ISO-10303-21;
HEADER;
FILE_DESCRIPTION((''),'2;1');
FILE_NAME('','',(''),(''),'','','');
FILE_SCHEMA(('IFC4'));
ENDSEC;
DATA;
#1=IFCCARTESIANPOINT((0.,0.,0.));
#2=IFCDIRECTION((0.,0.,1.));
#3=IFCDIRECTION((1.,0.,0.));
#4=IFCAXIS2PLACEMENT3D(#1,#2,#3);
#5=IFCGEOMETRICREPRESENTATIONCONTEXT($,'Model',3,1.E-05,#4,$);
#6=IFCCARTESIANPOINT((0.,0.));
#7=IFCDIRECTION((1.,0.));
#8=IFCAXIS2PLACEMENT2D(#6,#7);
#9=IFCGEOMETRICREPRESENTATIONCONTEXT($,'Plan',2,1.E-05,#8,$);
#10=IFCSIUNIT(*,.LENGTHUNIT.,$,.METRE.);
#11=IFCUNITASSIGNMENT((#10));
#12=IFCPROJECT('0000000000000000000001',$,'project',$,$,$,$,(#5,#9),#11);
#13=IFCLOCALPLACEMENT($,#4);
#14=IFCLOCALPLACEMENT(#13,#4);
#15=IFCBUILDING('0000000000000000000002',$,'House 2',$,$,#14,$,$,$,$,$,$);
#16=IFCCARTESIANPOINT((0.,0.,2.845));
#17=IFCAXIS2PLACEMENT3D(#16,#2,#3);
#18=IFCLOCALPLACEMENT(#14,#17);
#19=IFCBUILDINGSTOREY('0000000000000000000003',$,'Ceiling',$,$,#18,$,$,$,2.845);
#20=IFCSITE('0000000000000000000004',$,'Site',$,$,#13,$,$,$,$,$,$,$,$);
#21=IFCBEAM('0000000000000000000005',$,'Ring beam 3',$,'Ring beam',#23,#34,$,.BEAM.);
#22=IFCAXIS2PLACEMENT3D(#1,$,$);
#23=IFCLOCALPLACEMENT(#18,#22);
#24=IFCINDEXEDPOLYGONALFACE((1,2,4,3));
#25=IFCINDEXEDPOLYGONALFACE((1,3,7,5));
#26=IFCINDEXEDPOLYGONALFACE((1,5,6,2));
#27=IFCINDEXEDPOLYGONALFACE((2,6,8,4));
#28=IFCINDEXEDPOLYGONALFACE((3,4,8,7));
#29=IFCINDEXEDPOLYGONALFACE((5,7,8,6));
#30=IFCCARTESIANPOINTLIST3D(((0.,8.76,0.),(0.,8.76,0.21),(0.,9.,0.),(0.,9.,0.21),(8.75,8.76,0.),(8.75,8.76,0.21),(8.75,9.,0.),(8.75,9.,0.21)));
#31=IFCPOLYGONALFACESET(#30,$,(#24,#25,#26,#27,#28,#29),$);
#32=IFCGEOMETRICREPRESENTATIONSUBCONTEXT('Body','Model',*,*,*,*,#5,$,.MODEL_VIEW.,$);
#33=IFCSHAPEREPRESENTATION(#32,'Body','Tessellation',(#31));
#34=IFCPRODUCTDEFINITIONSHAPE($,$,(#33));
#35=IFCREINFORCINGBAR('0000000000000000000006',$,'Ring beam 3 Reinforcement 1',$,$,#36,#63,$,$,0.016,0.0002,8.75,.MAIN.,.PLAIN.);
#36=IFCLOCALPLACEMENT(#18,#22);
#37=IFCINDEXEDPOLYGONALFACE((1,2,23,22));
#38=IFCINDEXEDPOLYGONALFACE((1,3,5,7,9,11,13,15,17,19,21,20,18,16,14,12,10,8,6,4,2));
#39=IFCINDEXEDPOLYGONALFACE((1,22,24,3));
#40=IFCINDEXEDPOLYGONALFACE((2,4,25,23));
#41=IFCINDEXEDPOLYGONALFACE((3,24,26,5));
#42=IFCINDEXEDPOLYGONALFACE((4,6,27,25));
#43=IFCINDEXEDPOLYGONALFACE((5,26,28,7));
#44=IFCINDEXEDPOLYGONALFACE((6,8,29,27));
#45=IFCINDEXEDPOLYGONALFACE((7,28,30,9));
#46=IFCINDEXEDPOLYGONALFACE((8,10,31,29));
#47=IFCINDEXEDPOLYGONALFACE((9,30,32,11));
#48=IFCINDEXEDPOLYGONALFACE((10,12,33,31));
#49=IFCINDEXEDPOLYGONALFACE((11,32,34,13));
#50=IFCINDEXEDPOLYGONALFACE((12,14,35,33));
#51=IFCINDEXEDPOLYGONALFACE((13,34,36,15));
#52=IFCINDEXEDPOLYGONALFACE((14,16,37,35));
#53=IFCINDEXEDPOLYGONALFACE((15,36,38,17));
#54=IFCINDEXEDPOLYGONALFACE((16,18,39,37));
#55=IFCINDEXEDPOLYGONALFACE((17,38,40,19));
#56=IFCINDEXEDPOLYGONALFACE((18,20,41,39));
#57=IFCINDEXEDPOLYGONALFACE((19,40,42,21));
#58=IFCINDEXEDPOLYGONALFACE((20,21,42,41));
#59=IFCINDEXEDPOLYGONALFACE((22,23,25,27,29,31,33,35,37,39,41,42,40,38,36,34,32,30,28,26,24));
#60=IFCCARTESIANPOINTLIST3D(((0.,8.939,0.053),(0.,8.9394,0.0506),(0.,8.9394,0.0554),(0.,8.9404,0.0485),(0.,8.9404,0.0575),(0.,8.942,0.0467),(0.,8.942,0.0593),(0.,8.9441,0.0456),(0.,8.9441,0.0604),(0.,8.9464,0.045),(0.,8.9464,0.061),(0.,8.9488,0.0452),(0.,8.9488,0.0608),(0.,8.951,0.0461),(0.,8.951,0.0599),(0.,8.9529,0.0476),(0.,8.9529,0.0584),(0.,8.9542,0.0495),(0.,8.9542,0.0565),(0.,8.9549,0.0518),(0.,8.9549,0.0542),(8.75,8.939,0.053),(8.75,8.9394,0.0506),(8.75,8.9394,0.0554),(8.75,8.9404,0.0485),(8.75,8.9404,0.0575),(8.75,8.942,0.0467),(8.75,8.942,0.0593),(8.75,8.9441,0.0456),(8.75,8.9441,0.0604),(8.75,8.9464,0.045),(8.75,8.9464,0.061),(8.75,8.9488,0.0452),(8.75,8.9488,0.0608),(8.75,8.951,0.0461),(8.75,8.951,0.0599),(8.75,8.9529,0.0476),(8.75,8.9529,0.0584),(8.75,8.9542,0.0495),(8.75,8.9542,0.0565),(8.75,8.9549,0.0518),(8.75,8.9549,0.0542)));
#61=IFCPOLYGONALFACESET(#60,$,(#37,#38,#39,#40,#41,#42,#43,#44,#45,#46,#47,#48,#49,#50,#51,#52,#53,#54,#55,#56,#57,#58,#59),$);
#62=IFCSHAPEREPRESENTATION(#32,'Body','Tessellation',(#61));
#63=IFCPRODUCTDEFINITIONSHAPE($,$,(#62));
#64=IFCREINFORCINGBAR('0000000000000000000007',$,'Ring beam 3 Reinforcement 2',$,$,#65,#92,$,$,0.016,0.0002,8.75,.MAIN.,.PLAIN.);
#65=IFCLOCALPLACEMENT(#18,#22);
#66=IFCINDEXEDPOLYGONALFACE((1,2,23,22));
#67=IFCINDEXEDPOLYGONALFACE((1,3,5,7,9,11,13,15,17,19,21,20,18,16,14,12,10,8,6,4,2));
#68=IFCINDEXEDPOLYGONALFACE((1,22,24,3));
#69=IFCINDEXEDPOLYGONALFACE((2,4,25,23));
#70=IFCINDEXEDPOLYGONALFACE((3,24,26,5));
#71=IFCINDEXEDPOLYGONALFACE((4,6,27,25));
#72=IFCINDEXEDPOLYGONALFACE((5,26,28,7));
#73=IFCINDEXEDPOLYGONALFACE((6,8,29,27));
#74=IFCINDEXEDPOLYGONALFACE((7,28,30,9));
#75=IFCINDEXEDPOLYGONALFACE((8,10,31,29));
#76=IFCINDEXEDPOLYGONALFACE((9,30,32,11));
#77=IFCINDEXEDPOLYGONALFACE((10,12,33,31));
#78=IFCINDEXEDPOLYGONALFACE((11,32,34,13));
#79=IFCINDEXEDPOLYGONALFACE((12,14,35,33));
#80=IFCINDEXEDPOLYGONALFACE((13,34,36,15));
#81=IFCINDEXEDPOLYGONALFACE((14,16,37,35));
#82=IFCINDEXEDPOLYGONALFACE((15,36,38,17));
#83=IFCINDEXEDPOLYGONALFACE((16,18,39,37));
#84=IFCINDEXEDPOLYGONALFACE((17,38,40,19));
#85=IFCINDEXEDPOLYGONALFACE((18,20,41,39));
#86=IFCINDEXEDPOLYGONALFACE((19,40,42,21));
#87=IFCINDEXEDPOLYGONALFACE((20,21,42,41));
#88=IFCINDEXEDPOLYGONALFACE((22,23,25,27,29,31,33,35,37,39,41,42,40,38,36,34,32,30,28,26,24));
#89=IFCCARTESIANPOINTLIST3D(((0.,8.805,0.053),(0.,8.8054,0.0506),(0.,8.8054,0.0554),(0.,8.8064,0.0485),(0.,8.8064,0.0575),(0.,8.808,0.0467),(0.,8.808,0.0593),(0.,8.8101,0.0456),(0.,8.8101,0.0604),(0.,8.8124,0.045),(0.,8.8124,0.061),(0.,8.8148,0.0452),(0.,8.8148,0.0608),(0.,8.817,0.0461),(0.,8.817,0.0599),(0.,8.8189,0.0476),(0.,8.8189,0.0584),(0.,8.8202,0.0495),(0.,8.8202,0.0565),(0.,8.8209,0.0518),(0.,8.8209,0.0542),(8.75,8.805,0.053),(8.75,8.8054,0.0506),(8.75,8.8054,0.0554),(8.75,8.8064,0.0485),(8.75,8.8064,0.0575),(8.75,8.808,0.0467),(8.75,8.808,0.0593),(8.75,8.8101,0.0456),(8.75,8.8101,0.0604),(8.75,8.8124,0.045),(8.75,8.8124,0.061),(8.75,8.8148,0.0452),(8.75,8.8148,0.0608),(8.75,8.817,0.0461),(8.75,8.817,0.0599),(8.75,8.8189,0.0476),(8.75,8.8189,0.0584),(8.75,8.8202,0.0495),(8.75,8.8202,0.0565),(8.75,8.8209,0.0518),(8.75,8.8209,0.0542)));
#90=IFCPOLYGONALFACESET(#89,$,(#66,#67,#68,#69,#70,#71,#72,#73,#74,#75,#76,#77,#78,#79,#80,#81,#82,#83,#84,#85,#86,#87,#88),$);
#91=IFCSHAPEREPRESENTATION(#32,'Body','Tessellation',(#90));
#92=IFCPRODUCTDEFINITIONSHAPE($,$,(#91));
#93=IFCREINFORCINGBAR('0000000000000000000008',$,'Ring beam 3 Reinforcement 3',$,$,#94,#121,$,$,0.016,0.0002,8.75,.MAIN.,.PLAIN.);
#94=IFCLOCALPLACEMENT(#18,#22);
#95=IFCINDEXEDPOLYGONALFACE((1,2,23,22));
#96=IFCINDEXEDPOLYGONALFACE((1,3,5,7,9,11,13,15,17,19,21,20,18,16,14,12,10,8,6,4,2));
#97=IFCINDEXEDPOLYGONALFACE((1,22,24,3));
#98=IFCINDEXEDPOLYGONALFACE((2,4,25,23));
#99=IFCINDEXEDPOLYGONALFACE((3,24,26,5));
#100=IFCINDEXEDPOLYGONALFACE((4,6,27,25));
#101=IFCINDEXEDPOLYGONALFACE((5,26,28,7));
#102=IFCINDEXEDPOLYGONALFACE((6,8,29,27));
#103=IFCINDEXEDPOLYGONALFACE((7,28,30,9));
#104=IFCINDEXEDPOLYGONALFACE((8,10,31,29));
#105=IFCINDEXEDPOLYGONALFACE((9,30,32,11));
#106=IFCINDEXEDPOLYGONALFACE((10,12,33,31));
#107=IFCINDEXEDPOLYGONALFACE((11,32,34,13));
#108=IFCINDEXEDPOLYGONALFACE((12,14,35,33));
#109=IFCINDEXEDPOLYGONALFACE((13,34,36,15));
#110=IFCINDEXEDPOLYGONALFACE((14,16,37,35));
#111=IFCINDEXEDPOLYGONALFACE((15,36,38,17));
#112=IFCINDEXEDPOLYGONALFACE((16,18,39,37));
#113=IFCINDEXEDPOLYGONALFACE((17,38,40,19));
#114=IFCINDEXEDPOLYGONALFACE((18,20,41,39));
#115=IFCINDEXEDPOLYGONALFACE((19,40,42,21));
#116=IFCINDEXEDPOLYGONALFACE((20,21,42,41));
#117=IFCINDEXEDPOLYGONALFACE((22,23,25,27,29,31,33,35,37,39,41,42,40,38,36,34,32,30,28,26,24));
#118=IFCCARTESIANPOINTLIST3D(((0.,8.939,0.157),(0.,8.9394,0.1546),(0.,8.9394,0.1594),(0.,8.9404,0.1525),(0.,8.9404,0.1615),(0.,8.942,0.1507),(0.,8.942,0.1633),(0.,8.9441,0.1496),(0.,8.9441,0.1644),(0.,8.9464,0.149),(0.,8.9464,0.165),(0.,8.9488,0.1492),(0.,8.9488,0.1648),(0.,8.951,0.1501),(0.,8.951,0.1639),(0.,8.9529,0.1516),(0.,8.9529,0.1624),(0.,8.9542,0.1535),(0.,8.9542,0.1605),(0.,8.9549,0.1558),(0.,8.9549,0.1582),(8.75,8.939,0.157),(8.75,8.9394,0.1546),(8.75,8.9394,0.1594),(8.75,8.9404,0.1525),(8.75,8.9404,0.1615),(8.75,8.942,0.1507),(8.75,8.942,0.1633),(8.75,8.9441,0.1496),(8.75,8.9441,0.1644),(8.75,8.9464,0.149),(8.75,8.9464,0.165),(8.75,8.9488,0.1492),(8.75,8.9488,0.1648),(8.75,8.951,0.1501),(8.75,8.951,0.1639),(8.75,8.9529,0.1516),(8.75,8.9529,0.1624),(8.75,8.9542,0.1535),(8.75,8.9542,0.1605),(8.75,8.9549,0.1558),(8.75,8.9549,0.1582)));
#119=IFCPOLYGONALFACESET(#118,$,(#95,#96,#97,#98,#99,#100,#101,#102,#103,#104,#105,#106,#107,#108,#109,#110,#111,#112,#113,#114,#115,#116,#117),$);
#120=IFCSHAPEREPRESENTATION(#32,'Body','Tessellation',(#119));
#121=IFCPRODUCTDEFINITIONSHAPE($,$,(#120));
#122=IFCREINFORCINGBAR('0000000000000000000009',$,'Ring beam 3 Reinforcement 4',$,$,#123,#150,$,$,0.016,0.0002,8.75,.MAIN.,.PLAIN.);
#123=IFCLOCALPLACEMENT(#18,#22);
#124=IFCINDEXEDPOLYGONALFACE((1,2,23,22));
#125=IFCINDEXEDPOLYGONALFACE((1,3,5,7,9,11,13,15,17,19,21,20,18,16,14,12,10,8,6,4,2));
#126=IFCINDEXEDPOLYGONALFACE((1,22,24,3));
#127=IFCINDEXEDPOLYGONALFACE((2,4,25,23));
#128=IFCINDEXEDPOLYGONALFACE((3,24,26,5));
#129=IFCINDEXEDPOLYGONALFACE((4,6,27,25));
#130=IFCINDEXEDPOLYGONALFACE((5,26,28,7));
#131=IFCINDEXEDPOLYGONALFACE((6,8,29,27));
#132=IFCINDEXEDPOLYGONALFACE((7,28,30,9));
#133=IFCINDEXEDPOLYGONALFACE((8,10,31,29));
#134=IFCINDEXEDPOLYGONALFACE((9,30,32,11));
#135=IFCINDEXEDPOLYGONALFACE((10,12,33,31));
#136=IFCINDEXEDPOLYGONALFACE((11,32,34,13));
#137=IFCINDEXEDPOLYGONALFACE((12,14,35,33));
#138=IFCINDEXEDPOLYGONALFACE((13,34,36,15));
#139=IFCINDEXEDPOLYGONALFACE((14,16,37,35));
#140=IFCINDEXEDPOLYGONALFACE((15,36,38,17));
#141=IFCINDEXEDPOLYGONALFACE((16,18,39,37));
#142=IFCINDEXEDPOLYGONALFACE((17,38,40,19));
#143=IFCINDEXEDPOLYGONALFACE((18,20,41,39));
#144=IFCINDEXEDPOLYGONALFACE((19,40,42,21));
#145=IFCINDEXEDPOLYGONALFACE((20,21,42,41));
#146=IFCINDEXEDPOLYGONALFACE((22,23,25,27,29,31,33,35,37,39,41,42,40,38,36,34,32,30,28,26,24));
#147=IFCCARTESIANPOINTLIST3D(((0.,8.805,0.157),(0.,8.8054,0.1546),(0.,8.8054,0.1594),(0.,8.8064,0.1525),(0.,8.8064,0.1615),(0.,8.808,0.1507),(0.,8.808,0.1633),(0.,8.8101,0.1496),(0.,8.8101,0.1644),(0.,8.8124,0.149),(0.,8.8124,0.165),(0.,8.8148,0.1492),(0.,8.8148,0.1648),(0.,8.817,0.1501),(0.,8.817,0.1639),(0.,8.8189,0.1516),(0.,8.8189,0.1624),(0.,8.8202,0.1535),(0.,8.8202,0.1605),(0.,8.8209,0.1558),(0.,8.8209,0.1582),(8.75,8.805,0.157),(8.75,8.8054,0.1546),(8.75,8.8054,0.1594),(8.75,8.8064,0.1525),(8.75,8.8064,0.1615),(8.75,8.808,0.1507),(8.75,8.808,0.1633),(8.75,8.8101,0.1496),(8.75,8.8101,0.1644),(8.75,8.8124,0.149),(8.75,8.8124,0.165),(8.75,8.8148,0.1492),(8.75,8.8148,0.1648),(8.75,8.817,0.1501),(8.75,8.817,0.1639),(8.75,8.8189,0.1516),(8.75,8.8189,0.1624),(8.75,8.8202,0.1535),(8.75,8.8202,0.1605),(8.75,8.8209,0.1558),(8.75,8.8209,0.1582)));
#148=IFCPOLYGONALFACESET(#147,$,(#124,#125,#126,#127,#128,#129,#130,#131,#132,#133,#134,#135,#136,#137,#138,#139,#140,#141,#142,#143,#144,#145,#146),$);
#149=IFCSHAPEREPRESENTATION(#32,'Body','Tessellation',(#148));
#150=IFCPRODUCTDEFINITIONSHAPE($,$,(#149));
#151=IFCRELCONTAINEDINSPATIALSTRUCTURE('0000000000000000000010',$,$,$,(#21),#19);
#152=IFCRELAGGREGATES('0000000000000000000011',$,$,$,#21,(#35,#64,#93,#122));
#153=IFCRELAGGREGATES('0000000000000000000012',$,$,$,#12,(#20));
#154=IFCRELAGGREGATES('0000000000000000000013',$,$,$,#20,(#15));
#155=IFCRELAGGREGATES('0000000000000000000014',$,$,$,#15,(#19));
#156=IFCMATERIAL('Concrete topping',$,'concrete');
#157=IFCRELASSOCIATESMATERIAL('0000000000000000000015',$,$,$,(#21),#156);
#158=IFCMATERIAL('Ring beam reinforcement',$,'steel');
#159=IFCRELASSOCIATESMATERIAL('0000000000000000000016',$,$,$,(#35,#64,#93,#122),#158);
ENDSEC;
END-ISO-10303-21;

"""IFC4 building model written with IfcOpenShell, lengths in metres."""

from ifc_helpers import new_model, si_unit, frame, origin_with_axes, origin_2d, origin_2d_with_axis, place, context, subcontext, project, spatial, circle_curve, rectangle, outline, extrude, material, element, aggregate, save


model = new_model("IFC4")

# Units and contexts
model_context = context("Model", 3, precision=1e-05, world=origin_with_axes())
plan_context = context("Plan", 2, precision=1e-05, world=origin_2d_with_axis())
body_context_1 = subcontext(model_context, "Body", "Model", "MODEL_VIEW")
ifc_project = project(units=[si_unit("LENGTHUNIT", "METRE")], contexts=[model_context, plan_context])

# Site, building, storey
site_placement = place(None, origin_with_axes())
building_placement = place(site_placement, origin_with_axes())
storey_placement = place(building_placement, frame((0.0, 0.0, 2.845), z_axis=(0.0, 0.0, 1.0), x_axis=(1.0, 0.0, 0.0)))
site = spatial("IfcSite", under=ifc_project, at=site_placement, Name="Site")
building = spatial("IfcBuilding", under=site, at=building_placement, Name="House 2")
storey = spatial("IfcBuildingStorey", under=building, at=storey_placement, Name="Ceiling", Elevation=2.845)

# Beam
ifc_material_1 = material(Name="Concrete topping", Category="concrete")
beam_1_placement = place(storey_placement, frame((8.75, 8.88, 0.105), z_axis=(0.0, 0.0, 1.0), x_axis=(-1.0, 0.0, 0.0)))
beam_1 = element("IfcBeam", 1, at=beam_1_placement, inside=storey, material=ifc_material_1, Name="Ring beam 3", ObjectType="Ring beam", PredefinedType="BEAM", context=body_context_1, shape_type="SweptSolid", body=[
    extrude(rectangle(XDim=0.24, YDim=0.21), frame((0.0, 0.0, 0.0), z_axis=(1.0, 0.0, 0.0), x_axis=(0.0, 1.0, 0.0)), (0.0, 0.0, 1.0), 8.75),
])

# Reinforcing bars
ifc_material_2 = material(Name="Ring beam reinforcement", Category="steel")
reinforcing_bar_1_placement = place(beam_1_placement, frame((0.0, -0.067, -0.052), z_axis=(0.0, 0.0, 1.0), x_axis=(1.0, 0.0, 0.0)))
reinforcing_bar_1 = element("IfcReinforcingBar", 2, at=reinforcing_bar_1_placement, material=ifc_material_2, Name="Ring beam 3 Reinforcement 1", BarLength=8.75, BarSurface="PLAIN", CrossSectionArea=0.0002, NominalDiameter=0.016, PredefinedType="MAIN", context=body_context_1, shape_type="SweptSolid", body=[
    extrude(outline(circle_curve(origin_2d(), 0.008)), frame((0.0, 0.0, 0.0), z_axis=(1.0, 0.0, 0.0), x_axis=(0.0, 1.0, 0.0)), (0.0, 0.0, 1.0), 8.75),
])
reinforcing_bar_2_placement = place(beam_1_placement, frame((0.0, 0.067, -0.052), z_axis=(0.0, 0.0, 1.0), x_axis=(1.0, 0.0, 0.0)))
reinforcing_bar_2 = element("IfcReinforcingBar", 3, at=reinforcing_bar_2_placement, material=ifc_material_2, Name="Ring beam 3 Reinforcement 2", BarLength=8.75, BarSurface="PLAIN", CrossSectionArea=0.0002, NominalDiameter=0.016, PredefinedType="MAIN", context=body_context_1, shape_type="SweptSolid", body=[
    extrude(outline(circle_curve(origin_2d(), 0.008)), frame((0.0, 0.0, 0.0), z_axis=(1.0, 0.0, 0.0), x_axis=(0.0, 1.0, 0.0)), (0.0, 0.0, 1.0), 8.75),
])
reinforcing_bar_3_placement = place(beam_1_placement, frame((0.0, -0.067, 0.052), z_axis=(0.0, 0.0, 1.0), x_axis=(1.0, 0.0, 0.0)))
reinforcing_bar_3 = element("IfcReinforcingBar", 4, at=reinforcing_bar_3_placement, material=ifc_material_2, Name="Ring beam 3 Reinforcement 3", BarLength=8.75, BarSurface="PLAIN", CrossSectionArea=0.0002, NominalDiameter=0.016, PredefinedType="MAIN", context=body_context_1, shape_type="SweptSolid", body=[
    extrude(outline(circle_curve(origin_2d(), 0.008)), frame((0.0, 0.0, 0.0), z_axis=(1.0, 0.0, 0.0), x_axis=(0.0, 1.0, 0.0)), (0.0, 0.0, 1.0), 8.75),
])
reinforcing_bar_4_placement = place(beam_1_placement, frame((0.0, 0.067, 0.052), z_axis=(0.0, 0.0, 1.0), x_axis=(1.0, 0.0, 0.0)))
reinforcing_bar_4 = element("IfcReinforcingBar", 5, at=reinforcing_bar_4_placement, material=ifc_material_2, Name="Ring beam 3 Reinforcement 4", BarLength=8.75, BarSurface="PLAIN", CrossSectionArea=0.0002, NominalDiameter=0.016, PredefinedType="MAIN", context=body_context_1, shape_type="SweptSolid", body=[
    extrude(outline(circle_curve(origin_2d(), 0.008)), frame((0.0, 0.0, 0.0), z_axis=(1.0, 0.0, 0.0), x_axis=(0.0, 1.0, 0.0)), (0.0, 0.0, 1.0), 8.75),
])
aggregate(beam_1, [reinforcing_bar_1, reinforcing_bar_2, reinforcing_bar_3, reinforcing_bar_4])

save(model, "model.ifc")
